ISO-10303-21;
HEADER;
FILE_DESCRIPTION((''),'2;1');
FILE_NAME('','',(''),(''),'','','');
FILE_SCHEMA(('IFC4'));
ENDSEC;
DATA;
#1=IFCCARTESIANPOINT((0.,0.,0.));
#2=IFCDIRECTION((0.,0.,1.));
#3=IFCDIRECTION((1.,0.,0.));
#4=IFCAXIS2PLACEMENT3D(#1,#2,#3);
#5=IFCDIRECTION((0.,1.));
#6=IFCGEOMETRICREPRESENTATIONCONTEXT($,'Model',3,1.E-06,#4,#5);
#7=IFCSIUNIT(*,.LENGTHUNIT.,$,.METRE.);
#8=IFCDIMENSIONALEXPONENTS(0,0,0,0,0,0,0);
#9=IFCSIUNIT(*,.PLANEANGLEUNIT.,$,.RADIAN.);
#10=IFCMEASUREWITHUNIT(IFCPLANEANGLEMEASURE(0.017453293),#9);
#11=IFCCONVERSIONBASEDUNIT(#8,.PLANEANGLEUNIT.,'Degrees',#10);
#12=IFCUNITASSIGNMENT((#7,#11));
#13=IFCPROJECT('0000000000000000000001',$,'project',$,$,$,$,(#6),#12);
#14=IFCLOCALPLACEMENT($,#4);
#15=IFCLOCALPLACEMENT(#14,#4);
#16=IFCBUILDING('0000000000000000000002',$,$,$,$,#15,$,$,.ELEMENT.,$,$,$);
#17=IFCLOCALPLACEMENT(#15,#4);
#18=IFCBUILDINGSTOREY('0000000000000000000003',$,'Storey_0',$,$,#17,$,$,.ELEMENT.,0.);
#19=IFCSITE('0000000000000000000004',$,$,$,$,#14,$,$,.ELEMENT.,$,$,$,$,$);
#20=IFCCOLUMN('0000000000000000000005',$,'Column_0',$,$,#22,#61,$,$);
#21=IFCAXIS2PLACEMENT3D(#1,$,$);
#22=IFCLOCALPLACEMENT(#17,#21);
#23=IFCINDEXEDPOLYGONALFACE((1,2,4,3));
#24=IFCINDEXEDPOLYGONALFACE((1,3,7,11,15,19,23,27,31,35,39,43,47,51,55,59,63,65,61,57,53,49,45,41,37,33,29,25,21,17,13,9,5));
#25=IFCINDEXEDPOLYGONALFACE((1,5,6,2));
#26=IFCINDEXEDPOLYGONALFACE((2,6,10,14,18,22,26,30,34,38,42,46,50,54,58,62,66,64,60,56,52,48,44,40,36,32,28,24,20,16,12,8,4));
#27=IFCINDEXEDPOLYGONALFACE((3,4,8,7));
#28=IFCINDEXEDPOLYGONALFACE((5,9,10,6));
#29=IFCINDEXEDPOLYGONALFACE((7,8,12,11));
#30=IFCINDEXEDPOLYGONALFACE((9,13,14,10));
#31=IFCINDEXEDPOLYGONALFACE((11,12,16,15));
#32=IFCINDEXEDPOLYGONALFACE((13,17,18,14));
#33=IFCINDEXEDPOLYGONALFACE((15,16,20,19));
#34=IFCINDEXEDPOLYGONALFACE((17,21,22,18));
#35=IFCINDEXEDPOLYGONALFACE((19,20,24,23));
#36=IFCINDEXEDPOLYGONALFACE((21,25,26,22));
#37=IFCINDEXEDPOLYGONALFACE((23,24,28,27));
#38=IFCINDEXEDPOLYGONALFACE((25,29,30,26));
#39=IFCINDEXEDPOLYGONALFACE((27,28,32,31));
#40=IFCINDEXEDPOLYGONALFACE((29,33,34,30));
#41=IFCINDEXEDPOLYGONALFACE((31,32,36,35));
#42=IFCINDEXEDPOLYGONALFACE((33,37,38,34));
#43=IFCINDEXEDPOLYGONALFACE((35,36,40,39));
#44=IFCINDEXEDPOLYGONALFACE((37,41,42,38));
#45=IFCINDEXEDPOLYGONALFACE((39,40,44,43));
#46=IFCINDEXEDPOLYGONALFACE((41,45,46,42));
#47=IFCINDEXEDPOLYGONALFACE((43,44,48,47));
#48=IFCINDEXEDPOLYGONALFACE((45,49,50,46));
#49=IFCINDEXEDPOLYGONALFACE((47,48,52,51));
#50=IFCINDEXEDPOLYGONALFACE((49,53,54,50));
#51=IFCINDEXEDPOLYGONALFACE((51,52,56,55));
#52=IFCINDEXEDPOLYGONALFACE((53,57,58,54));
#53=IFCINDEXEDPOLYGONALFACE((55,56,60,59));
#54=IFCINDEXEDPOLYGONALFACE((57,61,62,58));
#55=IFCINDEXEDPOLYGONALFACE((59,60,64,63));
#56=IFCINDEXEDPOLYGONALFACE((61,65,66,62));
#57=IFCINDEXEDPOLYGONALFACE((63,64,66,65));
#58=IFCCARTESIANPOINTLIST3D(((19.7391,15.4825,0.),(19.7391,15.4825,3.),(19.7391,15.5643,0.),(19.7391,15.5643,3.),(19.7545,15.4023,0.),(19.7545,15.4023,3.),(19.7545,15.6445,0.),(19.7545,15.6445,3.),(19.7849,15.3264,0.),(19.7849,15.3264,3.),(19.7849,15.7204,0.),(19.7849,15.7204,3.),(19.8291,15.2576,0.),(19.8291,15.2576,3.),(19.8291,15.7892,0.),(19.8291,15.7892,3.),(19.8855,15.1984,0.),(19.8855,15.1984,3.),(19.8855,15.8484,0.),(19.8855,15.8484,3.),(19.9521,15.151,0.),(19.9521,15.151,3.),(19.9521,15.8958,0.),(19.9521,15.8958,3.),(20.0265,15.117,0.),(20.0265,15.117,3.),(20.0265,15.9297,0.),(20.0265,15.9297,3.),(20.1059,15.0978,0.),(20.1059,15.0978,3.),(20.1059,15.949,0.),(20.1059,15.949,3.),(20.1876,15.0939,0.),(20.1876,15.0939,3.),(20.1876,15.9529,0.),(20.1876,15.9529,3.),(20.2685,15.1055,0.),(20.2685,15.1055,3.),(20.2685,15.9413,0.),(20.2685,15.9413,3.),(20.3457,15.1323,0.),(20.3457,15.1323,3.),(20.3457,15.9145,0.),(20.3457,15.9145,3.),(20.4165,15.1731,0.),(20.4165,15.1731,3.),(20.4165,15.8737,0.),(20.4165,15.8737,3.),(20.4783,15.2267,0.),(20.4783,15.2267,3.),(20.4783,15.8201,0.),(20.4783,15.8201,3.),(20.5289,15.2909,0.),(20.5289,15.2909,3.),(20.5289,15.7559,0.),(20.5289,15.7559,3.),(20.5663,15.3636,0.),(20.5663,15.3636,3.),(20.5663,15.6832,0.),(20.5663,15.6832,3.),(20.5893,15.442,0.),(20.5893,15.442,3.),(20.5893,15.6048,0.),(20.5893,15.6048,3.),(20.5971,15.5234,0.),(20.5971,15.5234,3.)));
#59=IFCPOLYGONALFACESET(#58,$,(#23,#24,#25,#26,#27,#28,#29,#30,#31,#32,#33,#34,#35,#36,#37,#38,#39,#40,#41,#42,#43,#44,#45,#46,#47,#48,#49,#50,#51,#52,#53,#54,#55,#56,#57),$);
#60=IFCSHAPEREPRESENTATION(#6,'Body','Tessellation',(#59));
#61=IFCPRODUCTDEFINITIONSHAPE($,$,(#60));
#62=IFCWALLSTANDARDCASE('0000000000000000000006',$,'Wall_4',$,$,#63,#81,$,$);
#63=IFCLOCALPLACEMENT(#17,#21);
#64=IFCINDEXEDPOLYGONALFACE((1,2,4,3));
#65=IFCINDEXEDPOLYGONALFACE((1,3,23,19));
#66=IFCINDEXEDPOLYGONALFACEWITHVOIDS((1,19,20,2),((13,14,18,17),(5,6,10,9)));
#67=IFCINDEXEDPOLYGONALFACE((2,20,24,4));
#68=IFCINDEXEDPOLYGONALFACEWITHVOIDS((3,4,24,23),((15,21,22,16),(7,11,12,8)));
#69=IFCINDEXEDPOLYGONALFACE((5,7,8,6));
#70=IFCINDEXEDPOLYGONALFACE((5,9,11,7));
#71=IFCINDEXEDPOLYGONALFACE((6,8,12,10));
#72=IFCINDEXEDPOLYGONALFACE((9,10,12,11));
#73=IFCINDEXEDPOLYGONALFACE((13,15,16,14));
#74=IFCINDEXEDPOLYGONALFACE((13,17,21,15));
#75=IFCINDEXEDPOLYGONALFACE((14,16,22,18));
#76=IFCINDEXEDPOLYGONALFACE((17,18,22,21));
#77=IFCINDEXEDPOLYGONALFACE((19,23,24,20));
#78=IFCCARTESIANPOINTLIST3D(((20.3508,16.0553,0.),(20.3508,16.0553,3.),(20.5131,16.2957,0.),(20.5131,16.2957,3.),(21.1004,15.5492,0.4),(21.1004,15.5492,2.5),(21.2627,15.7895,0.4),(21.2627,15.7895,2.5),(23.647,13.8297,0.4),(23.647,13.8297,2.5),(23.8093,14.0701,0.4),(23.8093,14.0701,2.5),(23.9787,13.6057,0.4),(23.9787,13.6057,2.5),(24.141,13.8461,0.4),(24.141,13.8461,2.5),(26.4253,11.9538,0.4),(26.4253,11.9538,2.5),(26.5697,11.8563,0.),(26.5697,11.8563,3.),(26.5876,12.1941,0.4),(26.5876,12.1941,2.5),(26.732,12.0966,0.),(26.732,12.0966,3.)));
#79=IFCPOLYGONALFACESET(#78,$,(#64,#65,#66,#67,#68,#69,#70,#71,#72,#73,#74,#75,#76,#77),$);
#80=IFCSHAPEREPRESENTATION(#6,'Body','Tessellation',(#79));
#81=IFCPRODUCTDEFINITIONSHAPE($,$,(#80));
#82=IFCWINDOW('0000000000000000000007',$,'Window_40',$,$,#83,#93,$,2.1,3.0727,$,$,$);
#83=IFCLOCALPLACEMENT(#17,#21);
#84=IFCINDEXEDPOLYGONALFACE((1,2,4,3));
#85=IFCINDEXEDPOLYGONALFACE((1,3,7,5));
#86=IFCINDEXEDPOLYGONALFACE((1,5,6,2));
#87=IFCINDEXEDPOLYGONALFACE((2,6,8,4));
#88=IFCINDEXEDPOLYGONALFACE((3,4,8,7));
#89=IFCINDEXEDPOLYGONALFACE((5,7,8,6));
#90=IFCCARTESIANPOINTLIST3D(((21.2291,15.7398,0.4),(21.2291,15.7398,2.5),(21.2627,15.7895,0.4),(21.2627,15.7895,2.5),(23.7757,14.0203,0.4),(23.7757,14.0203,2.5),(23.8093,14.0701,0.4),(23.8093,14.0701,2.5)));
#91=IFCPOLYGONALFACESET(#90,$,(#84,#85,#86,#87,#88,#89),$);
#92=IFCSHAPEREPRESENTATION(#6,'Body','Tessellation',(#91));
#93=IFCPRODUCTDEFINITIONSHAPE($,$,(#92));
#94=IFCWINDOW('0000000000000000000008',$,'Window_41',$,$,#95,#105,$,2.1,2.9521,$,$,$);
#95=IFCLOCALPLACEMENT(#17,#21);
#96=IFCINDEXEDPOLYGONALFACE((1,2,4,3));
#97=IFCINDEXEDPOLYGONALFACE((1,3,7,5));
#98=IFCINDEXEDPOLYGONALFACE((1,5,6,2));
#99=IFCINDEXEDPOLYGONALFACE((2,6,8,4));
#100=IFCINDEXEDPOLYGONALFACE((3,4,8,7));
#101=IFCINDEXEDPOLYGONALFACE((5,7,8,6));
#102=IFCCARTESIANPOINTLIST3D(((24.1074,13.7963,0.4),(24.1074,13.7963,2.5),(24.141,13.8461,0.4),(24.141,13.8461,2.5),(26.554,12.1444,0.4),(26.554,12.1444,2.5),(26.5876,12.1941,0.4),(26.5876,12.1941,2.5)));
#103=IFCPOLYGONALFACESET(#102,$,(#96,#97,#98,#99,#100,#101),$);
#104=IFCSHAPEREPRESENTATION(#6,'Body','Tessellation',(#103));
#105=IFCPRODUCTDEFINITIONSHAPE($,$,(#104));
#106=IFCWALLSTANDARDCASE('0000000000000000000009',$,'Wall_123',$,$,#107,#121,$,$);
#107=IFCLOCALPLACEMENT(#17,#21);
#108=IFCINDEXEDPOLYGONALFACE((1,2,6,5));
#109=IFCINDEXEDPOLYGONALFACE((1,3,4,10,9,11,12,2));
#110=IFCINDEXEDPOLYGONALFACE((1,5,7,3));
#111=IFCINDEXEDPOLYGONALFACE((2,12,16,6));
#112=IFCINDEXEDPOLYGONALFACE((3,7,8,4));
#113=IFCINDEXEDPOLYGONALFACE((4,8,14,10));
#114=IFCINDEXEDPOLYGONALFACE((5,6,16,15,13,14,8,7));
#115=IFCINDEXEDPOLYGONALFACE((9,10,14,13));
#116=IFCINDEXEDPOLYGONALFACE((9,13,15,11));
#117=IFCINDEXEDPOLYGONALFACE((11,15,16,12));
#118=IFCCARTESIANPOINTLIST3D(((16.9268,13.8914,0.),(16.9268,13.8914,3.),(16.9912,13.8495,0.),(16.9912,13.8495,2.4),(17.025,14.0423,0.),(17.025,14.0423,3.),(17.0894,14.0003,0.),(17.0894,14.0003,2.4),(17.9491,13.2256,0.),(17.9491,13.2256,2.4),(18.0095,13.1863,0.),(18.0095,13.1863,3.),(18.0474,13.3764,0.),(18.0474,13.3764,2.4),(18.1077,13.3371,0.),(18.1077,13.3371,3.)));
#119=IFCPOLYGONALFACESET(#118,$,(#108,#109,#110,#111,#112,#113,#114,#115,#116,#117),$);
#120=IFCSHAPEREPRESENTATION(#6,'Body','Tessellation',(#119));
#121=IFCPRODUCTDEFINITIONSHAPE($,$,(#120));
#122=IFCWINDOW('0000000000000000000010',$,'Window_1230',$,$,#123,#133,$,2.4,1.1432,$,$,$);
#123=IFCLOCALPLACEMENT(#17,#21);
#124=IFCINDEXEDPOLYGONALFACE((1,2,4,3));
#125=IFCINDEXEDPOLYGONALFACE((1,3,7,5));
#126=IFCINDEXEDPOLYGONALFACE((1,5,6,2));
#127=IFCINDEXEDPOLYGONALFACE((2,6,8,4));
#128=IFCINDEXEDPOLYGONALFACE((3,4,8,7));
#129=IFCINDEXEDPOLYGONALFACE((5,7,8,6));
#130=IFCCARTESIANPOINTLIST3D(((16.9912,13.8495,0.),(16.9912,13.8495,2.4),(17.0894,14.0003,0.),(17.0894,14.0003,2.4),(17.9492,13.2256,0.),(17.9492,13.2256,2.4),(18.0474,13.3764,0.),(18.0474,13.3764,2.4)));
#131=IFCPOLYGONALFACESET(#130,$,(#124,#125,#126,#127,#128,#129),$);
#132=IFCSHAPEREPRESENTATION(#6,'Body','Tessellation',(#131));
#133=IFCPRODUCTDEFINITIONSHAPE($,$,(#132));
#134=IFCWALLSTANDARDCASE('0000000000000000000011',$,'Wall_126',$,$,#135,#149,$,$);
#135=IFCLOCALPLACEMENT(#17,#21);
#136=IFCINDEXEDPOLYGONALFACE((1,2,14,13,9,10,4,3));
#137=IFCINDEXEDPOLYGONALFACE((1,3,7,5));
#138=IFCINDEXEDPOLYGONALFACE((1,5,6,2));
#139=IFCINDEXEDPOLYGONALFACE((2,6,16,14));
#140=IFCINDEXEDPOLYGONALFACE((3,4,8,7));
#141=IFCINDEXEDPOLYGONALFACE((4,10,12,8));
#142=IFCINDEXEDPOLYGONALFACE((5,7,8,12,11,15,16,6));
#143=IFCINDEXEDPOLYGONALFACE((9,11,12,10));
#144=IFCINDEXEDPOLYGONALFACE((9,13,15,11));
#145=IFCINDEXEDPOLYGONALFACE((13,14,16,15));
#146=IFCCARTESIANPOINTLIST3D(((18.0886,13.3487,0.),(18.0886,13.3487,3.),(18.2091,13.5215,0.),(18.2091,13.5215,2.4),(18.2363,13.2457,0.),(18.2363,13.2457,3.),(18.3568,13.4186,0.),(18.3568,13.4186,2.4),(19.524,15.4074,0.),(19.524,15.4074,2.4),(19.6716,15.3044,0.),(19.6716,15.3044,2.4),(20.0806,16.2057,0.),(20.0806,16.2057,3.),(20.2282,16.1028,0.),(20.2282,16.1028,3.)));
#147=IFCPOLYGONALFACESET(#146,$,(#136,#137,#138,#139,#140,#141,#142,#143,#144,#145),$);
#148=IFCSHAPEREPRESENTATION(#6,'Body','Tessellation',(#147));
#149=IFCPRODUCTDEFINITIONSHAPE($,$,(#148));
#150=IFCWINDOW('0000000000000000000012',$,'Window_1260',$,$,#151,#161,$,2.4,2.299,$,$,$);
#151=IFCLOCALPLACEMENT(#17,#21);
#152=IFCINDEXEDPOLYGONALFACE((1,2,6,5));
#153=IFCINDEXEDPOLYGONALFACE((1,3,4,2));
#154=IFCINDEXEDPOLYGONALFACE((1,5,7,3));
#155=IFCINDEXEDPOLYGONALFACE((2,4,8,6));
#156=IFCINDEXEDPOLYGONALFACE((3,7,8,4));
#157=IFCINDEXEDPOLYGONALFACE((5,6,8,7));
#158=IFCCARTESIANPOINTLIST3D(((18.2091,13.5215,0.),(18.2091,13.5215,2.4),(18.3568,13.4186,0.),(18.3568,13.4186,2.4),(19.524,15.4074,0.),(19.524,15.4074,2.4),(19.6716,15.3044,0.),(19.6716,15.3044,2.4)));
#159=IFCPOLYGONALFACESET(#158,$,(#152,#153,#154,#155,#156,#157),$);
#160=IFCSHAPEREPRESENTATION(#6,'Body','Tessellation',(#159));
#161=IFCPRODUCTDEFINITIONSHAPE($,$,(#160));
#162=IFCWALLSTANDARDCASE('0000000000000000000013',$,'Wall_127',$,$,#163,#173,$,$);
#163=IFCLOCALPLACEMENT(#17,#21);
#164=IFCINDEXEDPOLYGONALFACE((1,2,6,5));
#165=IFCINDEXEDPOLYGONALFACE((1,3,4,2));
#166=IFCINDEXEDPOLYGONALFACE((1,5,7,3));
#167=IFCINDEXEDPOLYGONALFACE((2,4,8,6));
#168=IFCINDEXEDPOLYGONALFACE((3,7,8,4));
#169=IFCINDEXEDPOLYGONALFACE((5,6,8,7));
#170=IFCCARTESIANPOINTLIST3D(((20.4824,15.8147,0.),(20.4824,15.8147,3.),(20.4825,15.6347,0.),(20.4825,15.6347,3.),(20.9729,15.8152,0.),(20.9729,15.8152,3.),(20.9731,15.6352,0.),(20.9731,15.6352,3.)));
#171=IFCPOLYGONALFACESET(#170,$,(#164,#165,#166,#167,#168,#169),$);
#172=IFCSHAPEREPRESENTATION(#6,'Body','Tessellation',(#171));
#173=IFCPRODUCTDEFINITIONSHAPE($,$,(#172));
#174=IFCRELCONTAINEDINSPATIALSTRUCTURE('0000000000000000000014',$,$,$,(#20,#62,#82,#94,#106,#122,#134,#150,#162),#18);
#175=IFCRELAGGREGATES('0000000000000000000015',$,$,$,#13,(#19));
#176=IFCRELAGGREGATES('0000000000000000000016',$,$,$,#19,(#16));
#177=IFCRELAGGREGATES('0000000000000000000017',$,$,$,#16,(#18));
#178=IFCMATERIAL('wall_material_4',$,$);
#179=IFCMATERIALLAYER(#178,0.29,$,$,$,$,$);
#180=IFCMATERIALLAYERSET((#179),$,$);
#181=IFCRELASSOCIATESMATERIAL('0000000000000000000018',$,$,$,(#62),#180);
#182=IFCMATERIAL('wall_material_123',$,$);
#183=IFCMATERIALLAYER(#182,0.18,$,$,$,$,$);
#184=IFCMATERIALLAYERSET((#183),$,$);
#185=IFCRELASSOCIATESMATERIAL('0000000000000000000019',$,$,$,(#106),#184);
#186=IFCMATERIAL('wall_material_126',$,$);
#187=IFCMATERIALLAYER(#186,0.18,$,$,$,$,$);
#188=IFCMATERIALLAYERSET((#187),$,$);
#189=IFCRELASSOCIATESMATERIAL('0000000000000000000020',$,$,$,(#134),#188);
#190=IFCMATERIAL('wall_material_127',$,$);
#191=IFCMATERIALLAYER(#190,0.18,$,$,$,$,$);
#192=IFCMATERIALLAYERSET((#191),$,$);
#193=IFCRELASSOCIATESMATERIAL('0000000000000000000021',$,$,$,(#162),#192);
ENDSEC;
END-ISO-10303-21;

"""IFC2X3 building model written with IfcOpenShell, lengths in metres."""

from ifc_helpers import new_model, entity, si_unit, converted_unit, direction, frame, frame_2d, origin_with_axes, origin_2d_with_axis, place, context, project, spatial, polyline, rectangle, circle, outline, extrude, material, layer, layer_set, layer_usage, element, fill, save


model = new_model("IFC2X3")

# Units and contexts
model_context = context("Model", 3, precision=1e-06, world=origin_with_axes(), true_north=direction((0.0, 1.0)))
ifc_project = project(units=[si_unit("LENGTHUNIT", "METRE"), converted_unit("PLANEANGLEUNIT", "Degrees", entity("IfcPlaneAngleMeasure", 0.017453293), si_unit("PLANEANGLEUNIT", "RADIAN"), dimensions=[0, 0, 0, 0, 0, 0, 0])], contexts=[model_context])

# Site, building, storey
site_placement = place(None, origin_with_axes())
site = spatial("IfcSite", under=ifc_project, at=site_placement, CompositionType="ELEMENT")
building_placement = place(site_placement, origin_with_axes())
building = spatial("IfcBuilding", under=site, at=building_placement, CompositionType="ELEMENT")
storey_placement = place(building_placement, origin_with_axes())
storey = spatial("IfcBuildingStorey", under=building, at=storey_placement, Name="Storey_0", CompositionType="ELEMENT", Elevation=0.0)

# Column
column_placement = place(storey_placement, frame((20.1671, 15.5234, 0.0), z_axis=(0.0, 0.0, 1.0), x_axis=(1.0, 0.0, 0.0)))
element("IfcColumn", 1, at=column_placement, inside=storey, Name="Column_0", context=model_context, shape_type="SweptSolid", body=[
    extrude(circle(Radius=0.43, at=origin_2d_with_axis()), origin_with_axes(), (0.0, 0.0, 1.0), 3.0),
])

# Wall, openings, windows
ifc_material_1 = material(Name="wall_material_4")
ifc_layer_1 = layer(ifc_material_1, 0.29)
ifc_layer_set_1 = layer_set([ifc_layer_1])
ifc_layer_usage_1 = layer_usage(ifc_layer_set_1, "AXIS2", "NEGATIVE", 0.0)
wall_1_placement = place(storey_placement, frame((20.5131, 16.2957, 0.0), z_axis=(0.0, 0.0, 1.0), x_axis=(0.82877, -0.559589, 0.0)))
wall_1 = element("IfcWallStandardCase", 2, at=wall_1_placement, inside=storey, material=ifc_layer_usage_1, Name="Wall_4", context=model_context, shape_type="SweptSolid", body=[
    extrude(outline(polyline([(0.0, 0.0), (7.5038, 0.0), (7.5038, -0.29), (0.0, -0.29), (0.0, 0.0)])), origin_with_axes(), (0.0, 0.0, 1.0), 3.0),
])
opening_1_placement = place(wall_1_placement, frame((0.9045, 0.0, 0.4), z_axis=(0.0, 0.0, 1.0), x_axis=(1.0, 0.0, 0.0)))
opening_1 = element("IfcOpeningElement", 3, at=opening_1_placement, cuts=wall_1, context=model_context, shape_type="SweptSolid", body=[
    extrude(rectangle(XDim=3.0727, YDim=2.1, at=frame_2d((1.05, -1.5364), x_axis=(0.0, 1.0))), frame((0.0, 0.01, 0.0), z_axis=(0.0, -1.0, 0.0), x_axis=(0.0, 0.0, 1.0)), (0.0, 0.0, 1.0), 0.31),
])
opening_2_placement = place(wall_1_placement, frame((4.3775, 0.0, 0.4), z_axis=(0.0, 0.0, 1.0), x_axis=(1.0, 0.0, 0.0)))
opening_2 = element("IfcOpeningElement", 4, at=opening_2_placement, cuts=wall_1, context=model_context, shape_type="SweptSolid", body=[
    extrude(rectangle(XDim=2.9521, YDim=2.1, at=frame_2d((1.05, -1.476), x_axis=(0.0, 1.0))), frame((0.0, 0.01, 0.0), z_axis=(0.0, -1.0, 0.0), x_axis=(0.0, 0.0, 1.0)), (0.0, 0.0, 1.0), 0.31),
])
window_1_placement = place(storey_placement, frame((0.0, 0.0, 0.4), z_axis=(0.0, 0.0, 1.0), x_axis=(1.0, 0.0, 0.0)))
window_1 = element("IfcWindow", 5, at=window_1_placement, inside=storey, Name="Window_40", OverallHeight=2.1, OverallWidth=3.0727, context=model_context, shape_type="SweptSolid", body=[
    extrude(outline(polyline([(21.2627, 15.7895), (23.8093, 14.0701), (23.7757, 14.0203), (21.2291, 15.7398), (21.2627, 15.7895)])), origin_with_axes(), (0.0, 0.0, 1.0), 2.1),
])
fill(opening_1, window_1)
window_2_placement = place(storey_placement, frame((0.0, 0.0, 0.4), z_axis=(0.0, 0.0, 1.0), x_axis=(1.0, 0.0, 0.0)))
window_2 = element("IfcWindow", 6, at=window_2_placement, inside=storey, Name="Window_41", OverallHeight=2.1, OverallWidth=2.9521, context=model_context, shape_type="SweptSolid", body=[
    extrude(outline(polyline([(24.141, 13.8461), (26.5876, 12.1941), (26.554, 12.1444), (24.1074, 13.7963), (24.141, 13.8461)])), origin_with_axes(), (0.0, 0.0, 1.0), 2.1),
])
fill(opening_2, window_2)

# Walls, openings, windows
ifc_material_2 = material(Name="wall_material_123")
ifc_layer_2 = layer(ifc_material_2, 0.18)
ifc_layer_set_2 = layer_set([ifc_layer_2])
ifc_layer_usage_2 = layer_usage(ifc_layer_set_2, "AXIS2", "NEGATIVE", 0.0)
wall_2_placement = place(storey_placement, frame((18.0095, 13.1863, 0.0), z_axis=(0.0, 0.0, 1.0), x_axis=(-0.837957, 0.545736, 0.0)))
wall_2 = element("IfcWallStandardCase", 7, at=wall_2_placement, inside=storey, material=ifc_layer_usage_2, Name="Wall_123", context=model_context, shape_type="SweptSolid", body=[
    extrude(outline(polyline([(0.0, 0.0), (1.2921, 0.0), (1.2921, -0.18), (0.0, -0.18), (0.0, 0.0)])), origin_with_axes(), (0.0, 0.0, 1.0), 3.0),
])
opening_3_placement = place(wall_2_placement, frame((0.072, 0.0, 0.0), z_axis=(0.0, 0.0, 1.0), x_axis=(1.0, 0.0, 0.0)))
opening_3 = element("IfcOpeningElement", 8, at=opening_3_placement, cuts=wall_2, context=model_context, shape_type="SweptSolid", body=[
    extrude(rectangle(XDim=1.1432, YDim=2.4, at=frame_2d((1.2, -0.5716), x_axis=(0.0, 1.0))), frame((0.0, 0.01, 0.0), z_axis=(0.0, -1.0, 0.0), x_axis=(0.0, 0.0, 1.0)), (0.0, 0.0, 1.0), 0.2),
])
window_3_placement = place(storey_placement, origin_with_axes())
window_3 = element("IfcWindow", 9, at=window_3_placement, inside=storey, Name="Window_1230", OverallHeight=2.4, OverallWidth=1.1432, context=model_context, shape_type="SweptSolid", body=[
    extrude(outline(polyline([(17.9491, 13.2256), (16.9912, 13.8495), (17.0894, 14.0003), (18.0474, 13.3764), (17.9491, 13.2256)])), origin_with_axes(), (0.0, 0.0, 1.0), 2.4),
])
fill(opening_3, window_3)
ifc_material_3 = material(Name="wall_material_126")
ifc_layer_3 = layer(ifc_material_3, 0.18)
ifc_layer_set_3 = layer_set([ifc_layer_3])
ifc_layer_usage_3 = layer_usage(ifc_layer_set_3, "AXIS2", "NEGATIVE", 0.0)
wall_3_placement = place(storey_placement, frame((18.0886, 13.3487, 0.0), z_axis=(0.0, 0.0, 1.0), x_axis=(0.571927, 0.820304, 0.0)))
wall_3 = element("IfcWallStandardCase", 10, at=wall_3_placement, inside=storey, material=ifc_layer_usage_3, Name="Wall_126", context=model_context, shape_type="SweptSolid", body=[
    extrude(outline(polyline([(0.0, 0.0), (3.4829, 0.0), (3.4829, -0.18), (0.0, -0.18), (0.0, 0.0)])), origin_with_axes(), (0.0, 0.0, 1.0), 3.0),
])
opening_4_placement = place(wall_3_placement, frame((0.2107, 0.0, 0.0), z_axis=(0.0, 0.0, 1.0), x_axis=(1.0, 0.0, 0.0)))
opening_4 = element("IfcOpeningElement", 11, at=opening_4_placement, cuts=wall_3, context=model_context, shape_type="SweptSolid", body=[
    extrude(rectangle(XDim=2.299, YDim=2.4, at=frame_2d((1.2, -1.1495), x_axis=(0.0, 1.0))), frame((0.0, 0.01, 0.0), z_axis=(0.0, -1.0, 0.0), x_axis=(0.0, 0.0, 1.0)), (0.0, 0.0, 1.0), 0.2),
])
window_4_placement = place(storey_placement, origin_with_axes())
window_4 = element("IfcWindow", 12, at=window_4_placement, inside=storey, Name="Window_1260", OverallHeight=2.4, OverallWidth=2.299, context=model_context, shape_type="SweptSolid", body=[
    extrude(outline(polyline([(18.2091, 13.5215), (19.524, 15.4074), (19.6716, 15.3044), (18.3568, 13.4186), (18.2091, 13.5215)])), origin_with_axes(), (0.0, 0.0, 1.0), 2.4),
])
fill(opening_4, window_4)

# Wall
ifc_material_4 = material(Name="wall_material_127")
ifc_layer_4 = layer(ifc_material_4, 0.18)
ifc_layer_set_4 = layer_set([ifc_layer_4])
ifc_layer_usage_4 = layer_usage(ifc_layer_set_4, "AXIS2", "POSITIVE", 0.0)
wall_4_placement = place(storey_placement, frame((20.4825, 15.6347, 0.0), z_axis=(0.0, 0.0, 1.0), x_axis=(1.0, 0.000891, 0.0)))
element("IfcWallStandardCase", 13, at=wall_4_placement, inside=storey, material=ifc_layer_usage_4, Name="Wall_127", context=model_context, shape_type="SweptSolid", body=[
    extrude(outline(polyline([(0.0, 0.18), (0.4905, 0.18), (0.4905, 0.0), (0.0, 0.0), (0.0, 0.18)])), origin_with_axes(), (0.0, 0.0, 1.0), 3.0),
])

save(model, "model.ifc")
